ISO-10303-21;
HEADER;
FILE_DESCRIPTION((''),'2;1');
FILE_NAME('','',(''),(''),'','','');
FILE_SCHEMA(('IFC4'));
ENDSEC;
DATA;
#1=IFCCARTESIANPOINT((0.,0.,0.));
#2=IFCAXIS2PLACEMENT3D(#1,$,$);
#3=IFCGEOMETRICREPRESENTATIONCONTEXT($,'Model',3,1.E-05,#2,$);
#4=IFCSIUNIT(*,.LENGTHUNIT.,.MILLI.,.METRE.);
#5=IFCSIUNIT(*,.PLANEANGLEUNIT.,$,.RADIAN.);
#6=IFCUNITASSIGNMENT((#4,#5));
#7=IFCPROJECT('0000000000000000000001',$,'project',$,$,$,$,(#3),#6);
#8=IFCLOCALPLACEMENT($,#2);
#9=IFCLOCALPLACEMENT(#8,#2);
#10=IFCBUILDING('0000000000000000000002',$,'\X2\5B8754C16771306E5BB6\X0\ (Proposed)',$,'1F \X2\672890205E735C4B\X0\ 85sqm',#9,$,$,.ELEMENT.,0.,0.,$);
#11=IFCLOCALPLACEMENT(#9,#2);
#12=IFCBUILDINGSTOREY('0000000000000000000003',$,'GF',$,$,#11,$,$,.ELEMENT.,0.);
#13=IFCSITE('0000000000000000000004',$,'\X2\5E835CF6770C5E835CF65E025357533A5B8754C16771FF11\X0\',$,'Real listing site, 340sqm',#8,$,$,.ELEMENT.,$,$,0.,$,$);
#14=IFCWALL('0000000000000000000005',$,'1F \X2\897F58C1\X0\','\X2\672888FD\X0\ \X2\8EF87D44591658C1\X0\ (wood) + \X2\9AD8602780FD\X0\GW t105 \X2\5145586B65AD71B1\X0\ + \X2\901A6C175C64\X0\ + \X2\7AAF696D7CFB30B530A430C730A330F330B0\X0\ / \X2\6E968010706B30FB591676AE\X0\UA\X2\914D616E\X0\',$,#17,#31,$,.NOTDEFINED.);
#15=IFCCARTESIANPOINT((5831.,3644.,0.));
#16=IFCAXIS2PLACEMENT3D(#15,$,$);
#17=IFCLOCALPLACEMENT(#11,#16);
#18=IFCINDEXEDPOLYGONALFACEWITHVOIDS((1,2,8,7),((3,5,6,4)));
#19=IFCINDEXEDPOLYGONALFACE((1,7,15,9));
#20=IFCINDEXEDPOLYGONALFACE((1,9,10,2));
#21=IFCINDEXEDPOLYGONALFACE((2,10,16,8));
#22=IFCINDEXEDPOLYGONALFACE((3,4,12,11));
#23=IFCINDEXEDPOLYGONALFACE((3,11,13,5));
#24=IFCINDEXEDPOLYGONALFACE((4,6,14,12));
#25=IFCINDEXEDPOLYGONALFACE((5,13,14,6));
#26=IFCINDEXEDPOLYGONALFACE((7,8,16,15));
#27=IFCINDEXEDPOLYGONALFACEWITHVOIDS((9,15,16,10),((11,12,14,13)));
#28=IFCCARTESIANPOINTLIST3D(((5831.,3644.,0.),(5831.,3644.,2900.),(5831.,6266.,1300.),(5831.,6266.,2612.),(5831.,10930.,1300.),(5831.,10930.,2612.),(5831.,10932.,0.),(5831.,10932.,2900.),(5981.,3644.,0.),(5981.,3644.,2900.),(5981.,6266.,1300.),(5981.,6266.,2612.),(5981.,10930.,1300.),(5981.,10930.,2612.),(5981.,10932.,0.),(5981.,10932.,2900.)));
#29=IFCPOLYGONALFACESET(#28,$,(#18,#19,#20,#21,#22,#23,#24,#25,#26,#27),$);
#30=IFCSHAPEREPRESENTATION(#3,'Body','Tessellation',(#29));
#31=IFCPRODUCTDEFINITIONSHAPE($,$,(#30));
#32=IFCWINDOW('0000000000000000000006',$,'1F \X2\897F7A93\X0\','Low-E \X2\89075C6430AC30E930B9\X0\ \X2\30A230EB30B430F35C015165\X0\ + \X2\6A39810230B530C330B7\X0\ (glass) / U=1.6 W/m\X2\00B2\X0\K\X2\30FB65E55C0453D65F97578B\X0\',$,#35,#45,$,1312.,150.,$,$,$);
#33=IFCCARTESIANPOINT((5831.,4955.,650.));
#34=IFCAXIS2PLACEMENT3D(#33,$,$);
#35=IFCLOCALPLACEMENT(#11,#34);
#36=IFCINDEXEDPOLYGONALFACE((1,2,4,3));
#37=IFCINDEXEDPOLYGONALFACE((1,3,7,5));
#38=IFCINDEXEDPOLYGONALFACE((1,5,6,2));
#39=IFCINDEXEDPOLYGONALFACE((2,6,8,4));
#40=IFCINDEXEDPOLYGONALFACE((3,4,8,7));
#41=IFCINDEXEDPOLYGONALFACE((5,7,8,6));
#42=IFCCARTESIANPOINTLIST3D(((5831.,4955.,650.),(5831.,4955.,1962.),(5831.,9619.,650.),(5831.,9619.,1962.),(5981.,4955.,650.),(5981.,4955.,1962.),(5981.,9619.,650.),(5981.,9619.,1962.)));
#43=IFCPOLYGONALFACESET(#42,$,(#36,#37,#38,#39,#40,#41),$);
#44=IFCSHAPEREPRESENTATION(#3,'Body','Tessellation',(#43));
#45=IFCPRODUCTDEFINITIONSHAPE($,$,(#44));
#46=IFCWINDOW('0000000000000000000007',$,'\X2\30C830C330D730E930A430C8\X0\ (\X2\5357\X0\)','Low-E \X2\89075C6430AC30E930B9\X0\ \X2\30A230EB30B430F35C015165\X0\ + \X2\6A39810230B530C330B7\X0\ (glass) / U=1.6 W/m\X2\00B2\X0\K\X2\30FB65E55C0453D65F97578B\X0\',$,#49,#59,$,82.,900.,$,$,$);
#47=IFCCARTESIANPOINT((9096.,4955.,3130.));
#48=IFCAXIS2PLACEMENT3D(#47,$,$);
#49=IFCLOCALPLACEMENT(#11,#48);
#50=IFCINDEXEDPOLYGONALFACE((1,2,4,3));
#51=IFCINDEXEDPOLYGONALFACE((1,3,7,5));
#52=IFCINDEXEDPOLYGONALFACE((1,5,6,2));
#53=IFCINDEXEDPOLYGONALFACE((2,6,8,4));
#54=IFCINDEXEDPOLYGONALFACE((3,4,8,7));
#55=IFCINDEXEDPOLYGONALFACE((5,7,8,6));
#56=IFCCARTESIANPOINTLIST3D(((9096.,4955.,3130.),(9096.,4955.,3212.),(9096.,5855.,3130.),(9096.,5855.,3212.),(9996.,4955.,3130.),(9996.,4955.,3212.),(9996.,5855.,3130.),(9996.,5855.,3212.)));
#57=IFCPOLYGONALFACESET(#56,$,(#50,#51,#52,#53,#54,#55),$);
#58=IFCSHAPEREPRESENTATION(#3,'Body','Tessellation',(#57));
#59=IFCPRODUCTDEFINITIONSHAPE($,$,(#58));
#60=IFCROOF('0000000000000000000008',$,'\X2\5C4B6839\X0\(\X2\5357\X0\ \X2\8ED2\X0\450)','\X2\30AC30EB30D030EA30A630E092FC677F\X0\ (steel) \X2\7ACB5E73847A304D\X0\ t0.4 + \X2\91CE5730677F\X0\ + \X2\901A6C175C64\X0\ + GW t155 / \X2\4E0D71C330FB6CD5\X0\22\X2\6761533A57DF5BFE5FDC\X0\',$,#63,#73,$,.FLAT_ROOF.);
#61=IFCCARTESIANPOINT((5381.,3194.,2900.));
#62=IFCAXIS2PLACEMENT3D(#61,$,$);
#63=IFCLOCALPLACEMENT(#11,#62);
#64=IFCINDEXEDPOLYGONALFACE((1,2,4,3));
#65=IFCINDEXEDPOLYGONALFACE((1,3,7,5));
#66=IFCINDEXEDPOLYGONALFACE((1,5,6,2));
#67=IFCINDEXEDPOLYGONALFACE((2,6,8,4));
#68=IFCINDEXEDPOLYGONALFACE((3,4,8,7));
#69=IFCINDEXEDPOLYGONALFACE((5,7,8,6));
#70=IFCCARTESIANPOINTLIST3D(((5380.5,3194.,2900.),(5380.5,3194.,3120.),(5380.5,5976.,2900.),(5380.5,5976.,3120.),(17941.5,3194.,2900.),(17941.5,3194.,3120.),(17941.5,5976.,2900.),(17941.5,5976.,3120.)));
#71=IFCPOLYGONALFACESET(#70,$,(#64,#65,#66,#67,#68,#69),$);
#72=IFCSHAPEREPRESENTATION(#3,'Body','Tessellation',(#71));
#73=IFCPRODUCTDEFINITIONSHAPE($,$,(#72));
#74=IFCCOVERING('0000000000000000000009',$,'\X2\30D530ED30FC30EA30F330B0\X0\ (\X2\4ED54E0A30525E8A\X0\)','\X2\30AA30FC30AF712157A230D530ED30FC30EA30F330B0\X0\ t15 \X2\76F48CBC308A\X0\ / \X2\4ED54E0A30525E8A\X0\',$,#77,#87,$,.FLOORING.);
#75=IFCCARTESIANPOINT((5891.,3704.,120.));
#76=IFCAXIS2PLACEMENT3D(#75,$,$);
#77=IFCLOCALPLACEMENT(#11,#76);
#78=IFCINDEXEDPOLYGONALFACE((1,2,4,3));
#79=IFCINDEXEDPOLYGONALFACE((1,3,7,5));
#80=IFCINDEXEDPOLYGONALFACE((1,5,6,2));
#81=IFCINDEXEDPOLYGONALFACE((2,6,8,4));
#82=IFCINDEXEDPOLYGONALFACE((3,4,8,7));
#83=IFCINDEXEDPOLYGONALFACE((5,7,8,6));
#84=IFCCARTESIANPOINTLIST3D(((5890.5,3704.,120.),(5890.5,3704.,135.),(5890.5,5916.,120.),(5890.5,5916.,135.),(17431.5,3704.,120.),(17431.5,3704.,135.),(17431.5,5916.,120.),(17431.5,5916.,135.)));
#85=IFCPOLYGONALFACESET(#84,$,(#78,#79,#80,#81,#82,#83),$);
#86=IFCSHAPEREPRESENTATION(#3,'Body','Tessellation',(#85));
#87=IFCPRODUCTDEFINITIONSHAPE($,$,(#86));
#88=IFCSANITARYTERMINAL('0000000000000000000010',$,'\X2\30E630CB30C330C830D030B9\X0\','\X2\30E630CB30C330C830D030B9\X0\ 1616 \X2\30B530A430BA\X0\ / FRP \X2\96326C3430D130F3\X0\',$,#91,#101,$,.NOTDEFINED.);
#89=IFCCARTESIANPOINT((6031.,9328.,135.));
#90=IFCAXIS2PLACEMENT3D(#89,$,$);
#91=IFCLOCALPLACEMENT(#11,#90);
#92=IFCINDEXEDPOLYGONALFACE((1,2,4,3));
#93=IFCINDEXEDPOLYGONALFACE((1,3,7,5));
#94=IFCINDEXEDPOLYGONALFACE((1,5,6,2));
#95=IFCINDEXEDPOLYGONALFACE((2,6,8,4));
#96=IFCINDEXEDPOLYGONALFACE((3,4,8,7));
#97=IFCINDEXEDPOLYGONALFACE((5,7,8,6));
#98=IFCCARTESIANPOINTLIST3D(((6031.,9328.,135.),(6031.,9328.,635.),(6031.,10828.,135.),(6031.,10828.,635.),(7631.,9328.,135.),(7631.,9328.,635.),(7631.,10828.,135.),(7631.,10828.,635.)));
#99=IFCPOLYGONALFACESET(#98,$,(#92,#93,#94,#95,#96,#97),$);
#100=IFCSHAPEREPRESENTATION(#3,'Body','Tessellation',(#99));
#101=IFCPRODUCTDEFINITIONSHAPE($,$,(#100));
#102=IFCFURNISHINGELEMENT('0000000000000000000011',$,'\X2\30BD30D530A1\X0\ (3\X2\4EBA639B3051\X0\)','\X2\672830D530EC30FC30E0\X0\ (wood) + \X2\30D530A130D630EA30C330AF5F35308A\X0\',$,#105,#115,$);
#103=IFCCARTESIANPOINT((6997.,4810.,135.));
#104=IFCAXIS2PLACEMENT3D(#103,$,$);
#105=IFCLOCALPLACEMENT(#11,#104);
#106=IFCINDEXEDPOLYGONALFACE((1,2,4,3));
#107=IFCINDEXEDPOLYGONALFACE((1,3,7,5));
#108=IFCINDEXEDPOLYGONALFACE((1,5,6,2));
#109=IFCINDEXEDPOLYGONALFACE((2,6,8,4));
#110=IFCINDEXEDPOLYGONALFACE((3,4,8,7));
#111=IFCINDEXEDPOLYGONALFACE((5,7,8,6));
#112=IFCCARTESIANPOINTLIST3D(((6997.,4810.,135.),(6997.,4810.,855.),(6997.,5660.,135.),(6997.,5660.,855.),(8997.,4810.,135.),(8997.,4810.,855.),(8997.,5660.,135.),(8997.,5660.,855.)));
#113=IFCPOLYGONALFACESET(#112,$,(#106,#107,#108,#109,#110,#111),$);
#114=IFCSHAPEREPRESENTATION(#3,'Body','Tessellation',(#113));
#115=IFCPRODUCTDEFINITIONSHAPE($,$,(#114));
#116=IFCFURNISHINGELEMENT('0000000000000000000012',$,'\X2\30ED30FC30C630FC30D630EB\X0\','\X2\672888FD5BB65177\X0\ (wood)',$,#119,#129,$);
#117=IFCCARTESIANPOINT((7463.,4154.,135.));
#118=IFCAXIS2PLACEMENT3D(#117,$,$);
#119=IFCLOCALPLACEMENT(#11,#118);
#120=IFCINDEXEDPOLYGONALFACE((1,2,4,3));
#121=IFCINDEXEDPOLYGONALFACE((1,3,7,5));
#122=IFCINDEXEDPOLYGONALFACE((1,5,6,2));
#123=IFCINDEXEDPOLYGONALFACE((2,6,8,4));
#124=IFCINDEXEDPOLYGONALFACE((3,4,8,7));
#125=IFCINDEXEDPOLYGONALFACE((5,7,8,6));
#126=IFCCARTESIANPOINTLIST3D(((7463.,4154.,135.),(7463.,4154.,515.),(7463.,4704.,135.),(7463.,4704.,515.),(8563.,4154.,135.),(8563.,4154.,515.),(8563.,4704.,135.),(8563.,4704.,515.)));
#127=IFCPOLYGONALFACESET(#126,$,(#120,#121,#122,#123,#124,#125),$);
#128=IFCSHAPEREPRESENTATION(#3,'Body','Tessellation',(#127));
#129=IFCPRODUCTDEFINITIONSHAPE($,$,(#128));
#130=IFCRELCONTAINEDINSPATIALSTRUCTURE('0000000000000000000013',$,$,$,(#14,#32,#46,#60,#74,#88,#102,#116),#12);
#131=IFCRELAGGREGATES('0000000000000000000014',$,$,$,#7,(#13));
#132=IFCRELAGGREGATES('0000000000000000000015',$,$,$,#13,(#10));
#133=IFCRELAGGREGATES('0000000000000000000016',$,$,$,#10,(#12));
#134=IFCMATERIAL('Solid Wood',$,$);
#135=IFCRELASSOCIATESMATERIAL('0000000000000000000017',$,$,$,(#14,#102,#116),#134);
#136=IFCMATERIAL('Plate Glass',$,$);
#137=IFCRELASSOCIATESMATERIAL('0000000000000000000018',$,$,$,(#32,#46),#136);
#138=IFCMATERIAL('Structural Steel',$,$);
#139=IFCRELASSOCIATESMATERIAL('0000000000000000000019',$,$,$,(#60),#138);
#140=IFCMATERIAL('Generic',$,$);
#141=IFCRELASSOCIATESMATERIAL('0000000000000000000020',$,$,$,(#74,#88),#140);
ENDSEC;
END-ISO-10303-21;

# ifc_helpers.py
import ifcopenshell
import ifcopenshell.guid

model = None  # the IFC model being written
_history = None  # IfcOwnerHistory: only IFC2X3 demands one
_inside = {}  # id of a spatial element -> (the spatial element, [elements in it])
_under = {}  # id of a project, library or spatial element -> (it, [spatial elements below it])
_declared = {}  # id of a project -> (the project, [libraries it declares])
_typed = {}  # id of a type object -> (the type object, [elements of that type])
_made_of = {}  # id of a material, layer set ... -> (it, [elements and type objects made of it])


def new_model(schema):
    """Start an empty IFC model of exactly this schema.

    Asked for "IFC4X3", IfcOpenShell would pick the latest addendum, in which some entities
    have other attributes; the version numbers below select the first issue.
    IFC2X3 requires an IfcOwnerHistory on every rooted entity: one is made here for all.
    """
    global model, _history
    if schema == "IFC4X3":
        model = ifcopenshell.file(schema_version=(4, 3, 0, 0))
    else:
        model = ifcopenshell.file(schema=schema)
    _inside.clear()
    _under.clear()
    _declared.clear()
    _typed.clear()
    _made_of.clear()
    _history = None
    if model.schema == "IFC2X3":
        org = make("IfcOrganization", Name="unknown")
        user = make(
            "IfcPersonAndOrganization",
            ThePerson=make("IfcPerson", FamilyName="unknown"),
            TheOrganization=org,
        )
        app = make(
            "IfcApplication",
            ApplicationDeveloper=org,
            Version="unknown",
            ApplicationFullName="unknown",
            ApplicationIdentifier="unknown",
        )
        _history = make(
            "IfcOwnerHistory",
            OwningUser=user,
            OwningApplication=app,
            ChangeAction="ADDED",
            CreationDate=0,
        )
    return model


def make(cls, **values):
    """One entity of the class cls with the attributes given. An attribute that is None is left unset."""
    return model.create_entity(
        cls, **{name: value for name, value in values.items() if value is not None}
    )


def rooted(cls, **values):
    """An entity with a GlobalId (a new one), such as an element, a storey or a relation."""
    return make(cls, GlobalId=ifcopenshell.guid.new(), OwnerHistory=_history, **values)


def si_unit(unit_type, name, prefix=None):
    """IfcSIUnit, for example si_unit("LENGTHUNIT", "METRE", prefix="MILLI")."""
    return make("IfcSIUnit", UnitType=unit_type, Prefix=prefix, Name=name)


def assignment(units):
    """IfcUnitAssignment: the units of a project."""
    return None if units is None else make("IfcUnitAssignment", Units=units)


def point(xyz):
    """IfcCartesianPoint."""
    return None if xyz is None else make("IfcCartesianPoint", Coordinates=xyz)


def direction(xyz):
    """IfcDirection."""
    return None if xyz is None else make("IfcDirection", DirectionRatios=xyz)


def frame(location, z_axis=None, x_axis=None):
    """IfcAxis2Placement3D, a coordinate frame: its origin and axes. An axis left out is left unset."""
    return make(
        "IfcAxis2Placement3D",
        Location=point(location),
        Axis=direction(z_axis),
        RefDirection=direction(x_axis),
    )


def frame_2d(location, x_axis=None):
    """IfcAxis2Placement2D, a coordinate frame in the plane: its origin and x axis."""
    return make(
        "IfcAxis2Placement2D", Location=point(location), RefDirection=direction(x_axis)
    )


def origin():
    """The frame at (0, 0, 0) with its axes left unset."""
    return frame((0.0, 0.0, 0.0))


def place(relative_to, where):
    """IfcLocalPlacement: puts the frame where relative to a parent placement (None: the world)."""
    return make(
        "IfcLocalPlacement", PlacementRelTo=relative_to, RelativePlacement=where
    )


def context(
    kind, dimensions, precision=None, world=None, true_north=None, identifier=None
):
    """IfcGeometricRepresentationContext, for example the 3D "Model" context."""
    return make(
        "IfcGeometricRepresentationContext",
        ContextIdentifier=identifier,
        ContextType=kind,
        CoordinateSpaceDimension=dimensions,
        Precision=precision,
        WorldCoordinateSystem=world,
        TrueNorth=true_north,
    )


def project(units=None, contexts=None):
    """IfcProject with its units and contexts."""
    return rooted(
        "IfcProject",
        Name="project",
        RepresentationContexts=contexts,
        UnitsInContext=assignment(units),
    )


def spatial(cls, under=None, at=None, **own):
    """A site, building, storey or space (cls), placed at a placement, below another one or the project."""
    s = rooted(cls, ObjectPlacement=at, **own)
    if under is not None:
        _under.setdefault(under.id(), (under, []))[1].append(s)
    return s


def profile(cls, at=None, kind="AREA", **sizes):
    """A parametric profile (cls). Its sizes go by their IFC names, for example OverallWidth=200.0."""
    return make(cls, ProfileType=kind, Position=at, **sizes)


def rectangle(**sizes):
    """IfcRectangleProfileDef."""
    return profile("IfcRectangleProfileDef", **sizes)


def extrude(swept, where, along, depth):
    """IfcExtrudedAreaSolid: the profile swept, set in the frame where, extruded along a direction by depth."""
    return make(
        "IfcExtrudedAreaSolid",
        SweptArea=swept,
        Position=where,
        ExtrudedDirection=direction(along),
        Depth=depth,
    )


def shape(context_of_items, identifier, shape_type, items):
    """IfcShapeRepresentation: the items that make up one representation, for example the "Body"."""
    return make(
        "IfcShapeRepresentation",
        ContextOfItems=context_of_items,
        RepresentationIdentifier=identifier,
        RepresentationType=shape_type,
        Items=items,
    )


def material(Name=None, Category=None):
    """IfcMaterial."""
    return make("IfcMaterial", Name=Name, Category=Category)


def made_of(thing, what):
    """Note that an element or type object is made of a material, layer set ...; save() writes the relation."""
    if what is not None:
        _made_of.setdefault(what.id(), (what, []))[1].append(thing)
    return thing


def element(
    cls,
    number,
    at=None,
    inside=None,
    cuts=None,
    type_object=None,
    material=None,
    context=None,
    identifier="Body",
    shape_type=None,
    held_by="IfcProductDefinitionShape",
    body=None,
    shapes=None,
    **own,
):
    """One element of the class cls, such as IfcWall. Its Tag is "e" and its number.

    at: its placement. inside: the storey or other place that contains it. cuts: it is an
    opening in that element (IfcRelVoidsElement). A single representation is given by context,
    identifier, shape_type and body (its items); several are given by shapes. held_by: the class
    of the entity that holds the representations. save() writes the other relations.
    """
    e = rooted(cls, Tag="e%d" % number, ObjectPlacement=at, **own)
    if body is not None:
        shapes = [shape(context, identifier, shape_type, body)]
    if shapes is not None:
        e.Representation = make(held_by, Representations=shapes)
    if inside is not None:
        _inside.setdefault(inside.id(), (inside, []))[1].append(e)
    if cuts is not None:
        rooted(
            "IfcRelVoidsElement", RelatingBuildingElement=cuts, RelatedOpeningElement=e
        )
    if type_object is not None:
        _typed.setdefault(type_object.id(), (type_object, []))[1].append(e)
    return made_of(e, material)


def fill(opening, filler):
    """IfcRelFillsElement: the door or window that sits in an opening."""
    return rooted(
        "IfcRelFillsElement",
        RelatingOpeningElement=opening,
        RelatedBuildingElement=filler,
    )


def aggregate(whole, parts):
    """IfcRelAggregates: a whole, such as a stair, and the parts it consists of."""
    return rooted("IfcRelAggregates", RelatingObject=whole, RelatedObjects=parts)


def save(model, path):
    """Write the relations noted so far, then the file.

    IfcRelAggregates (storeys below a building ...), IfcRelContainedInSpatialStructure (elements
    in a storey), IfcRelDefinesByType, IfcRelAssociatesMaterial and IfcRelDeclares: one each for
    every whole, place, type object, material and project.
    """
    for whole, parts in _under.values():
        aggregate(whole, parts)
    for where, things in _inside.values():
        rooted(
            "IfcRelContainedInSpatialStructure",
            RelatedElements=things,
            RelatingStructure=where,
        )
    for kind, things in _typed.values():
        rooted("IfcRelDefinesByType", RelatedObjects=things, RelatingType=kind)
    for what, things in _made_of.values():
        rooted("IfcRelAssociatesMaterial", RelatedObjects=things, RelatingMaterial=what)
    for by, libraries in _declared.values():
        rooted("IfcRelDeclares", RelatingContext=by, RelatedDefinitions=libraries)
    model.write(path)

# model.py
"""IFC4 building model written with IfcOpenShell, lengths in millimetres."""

from ifc_helpers import new_model, si_unit, frame, frame_2d, origin, place, context, project, spatial, rectangle, extrude, material, element, fill, save


model = new_model("IFC4")

# Units and contexts
model_context = context("Model", 3, precision=1e-05, world=origin())
ifc_project = project(units=[si_unit("LENGTHUNIT", "METRE", prefix="MILLI"), si_unit("PLANEANGLEUNIT", "RADIAN")], contexts=[model_context])

# Site, building, storey
site_placement = place(None, origin())
site = spatial("IfcSite", under=ifc_project, at=site_placement, Name="広島県広島市南区宇品東１", ObjectType="Real listing site, 340sqm", CompositionType="ELEMENT", RefElevation=0.0)
building_placement = place(site_placement, origin())
building = spatial("IfcBuilding", under=site, at=building_placement, Name="宇品東の家 (Proposed)", ObjectType="1F 木造平屋 85sqm", CompositionType="ELEMENT", ElevationOfRefHeight=0.0, ElevationOfTerrain=0.0)
storey_placement = place(building_placement, origin())
storey = spatial("IfcBuildingStorey", under=building, at=storey_placement, Name="GF", CompositionType="ELEMENT", Elevation=0.0)

# Shared definitions
ifc_material_1 = material(Name="Solid Wood")

# Shared definitions
ifc_material_2 = material(Name="Plate Glass")

# Wall, opening, window
wall_1_placement = place(storey_placement, frame((5831.0, 3644.0, 0.0)))
wall_1 = element("IfcWall", 1, at=wall_1_placement, inside=storey, material=ifc_material_1, Name="1F 西壁", Description="木製 軸組外壁 (wood) + 高性能GW t105 充填断熱 + 通気層 + 窯業系サイディング / 準耐火・外皮UA配慮", PredefinedType="NOTDEFINED", context=model_context, shape_type="SweptSolid", body=[
    extrude(rectangle(XDim=150.0, YDim=7288.0, at=frame_2d((75.0, 3644.0))), frame((5831.0, 3644.0, 0.0)), (0.0, 0.0, 1.0), 2900.0),
])
opening_1_placement = place(storey_placement, frame((5831.0, 4955.0, 650.0)))
opening_1 = element("IfcOpeningElement", 2, at=opening_1_placement, cuts=wall_1, PredefinedType="NOTDEFINED", context=model_context, shape_type="SweptSolid", body=[
    extrude(rectangle(XDim=150.0, YDim=4664.0, at=frame_2d((75.0, 2332.0))), frame((5831.0, 4955.0, 650.0)), (0.0, 0.0, 1.0), 1312.0),
])
window_1_placement = place(storey_placement, frame((5831.0, 4955.0, 650.0)))
window_1 = element("IfcWindow", 3, at=window_1_placement, inside=storey, material=ifc_material_2, Name="1F 西窓", Description="Low-E 複層ガラス アルゴン封入 + 樹脂サッシ (glass) / U=1.6 W/m²K・日射取得型", OverallHeight=1312.0, OverallWidth=150.0, context=model_context, shape_type="SweptSolid", body=[
    extrude(rectangle(XDim=150.0, YDim=4664.0, at=frame_2d((75.0, 2332.0))), frame((5831.0, 4955.0, 650.0)), (0.0, 0.0, 1.0), 1312.0),
])
fill(opening_1, window_1)

# Window
window_2_placement = place(storey_placement, frame((9096.0, 4955.0, 3130.0)))
element("IfcWindow", 4, at=window_2_placement, inside=storey, material=ifc_material_2, Name="トップライト (南)", Description="Low-E 複層ガラス アルゴン封入 + 樹脂サッシ (glass) / U=1.6 W/m²K・日射取得型", OverallHeight=82.0, OverallWidth=900.0, context=model_context, shape_type="SweptSolid", body=[
    extrude(rectangle(XDim=900.0, YDim=900.0, at=frame_2d((450.0, 450.0))), frame((9096.0, 4955.0, 3130.0)), (0.0, 0.0, 1.0), 82.0),
])

# Roof
ifc_material_3 = material(Name="Structural Steel")
roof_1_placement = place(storey_placement, frame((5381.0, 3194.0, 2900.0)))
element("IfcRoof", 5, at=roof_1_placement, inside=storey, material=ifc_material_3, Name="屋根(南 軒450)", Description="ガルバリウム鋼板 (steel) 立平葺き t0.4 + 野地板 + 通気層 + GW t155 / 不燃・法22条区域対応", PredefinedType="FLAT_ROOF", context=model_context, shape_type="SweptSolid", body=[
    extrude(rectangle(XDim=12561.0, YDim=2782.0, at=frame_2d((6280.0, 1391.0))), frame((5381.0, 3194.0, 2900.0)), (0.0, 0.0, 1.0), 220.0),
])

# Covering
ifc_material_4 = material(Name="Generic")
covering_1_placement = place(storey_placement, frame((5891.0, 3704.0, 120.0)))
element("IfcCovering", 6, at=covering_1_placement, inside=storey, material=ifc_material_4, Name="フローリング (仕上げ床)", Description="オーク無垢フローリング t15 直貼り / 仕上げ床", PredefinedType="FLOORING", context=model_context, shape_type="SweptSolid", body=[
    extrude(rectangle(XDim=11541.0, YDim=2212.0, at=frame_2d((5770.0, 1106.0))), frame((5891.0, 3704.0, 120.0)), (0.0, 0.0, 1.0), 15.0),
])

# Sanitary terminal
sanitary_terminal_placement = place(storey_placement, frame((6031.0, 9328.0, 135.0)))
element("IfcSanitaryTerminal", 7, at=sanitary_terminal_placement, inside=storey, material=ifc_material_4, Name="ユニットバス", Description="ユニットバス 1616 サイズ / FRP 防水パン", PredefinedType="NOTDEFINED", context=model_context, shape_type="SweptSolid", body=[
    extrude(rectangle(XDim=1600.0, YDim=1500.0, at=frame_2d((800.0, 750.0))), frame((6031.0, 9328.0, 135.0)), (0.0, 0.0, 1.0), 500.0),
])

# Furnishing elements
furnishing_1_placement = place(storey_placement, frame((6997.0, 4810.0, 135.0)))
element("IfcFurnishingElement", 8, at=furnishing_1_placement, inside=storey, material=ifc_material_1, Name="ソファ (3人掛け)", Description="木フレーム (wood) + ファブリック張り", context=model_context, shape_type="SweptSolid", body=[
    extrude(rectangle(XDim=2000.0, YDim=850.0, at=frame_2d((1000.0, 425.0))), frame((6997.0, 4810.0, 135.0)), (0.0, 0.0, 1.0), 720.0),
])
furnishing_2_placement = place(storey_placement, frame((7463.0, 4154.0, 135.0)))
element("IfcFurnishingElement", 9, at=furnishing_2_placement, inside=storey, material=ifc_material_1, Name="ローテーブル", Description="木製家具 (wood)", context=model_context, shape_type="SweptSolid", body=[
    extrude(rectangle(XDim=1100.0, YDim=550.0, at=frame_2d((550.0, 275.0))), frame((7463.0, 4154.0, 135.0)), (0.0, 0.0, 1.0), 380.0),
])

save(model, "model.ifc")
